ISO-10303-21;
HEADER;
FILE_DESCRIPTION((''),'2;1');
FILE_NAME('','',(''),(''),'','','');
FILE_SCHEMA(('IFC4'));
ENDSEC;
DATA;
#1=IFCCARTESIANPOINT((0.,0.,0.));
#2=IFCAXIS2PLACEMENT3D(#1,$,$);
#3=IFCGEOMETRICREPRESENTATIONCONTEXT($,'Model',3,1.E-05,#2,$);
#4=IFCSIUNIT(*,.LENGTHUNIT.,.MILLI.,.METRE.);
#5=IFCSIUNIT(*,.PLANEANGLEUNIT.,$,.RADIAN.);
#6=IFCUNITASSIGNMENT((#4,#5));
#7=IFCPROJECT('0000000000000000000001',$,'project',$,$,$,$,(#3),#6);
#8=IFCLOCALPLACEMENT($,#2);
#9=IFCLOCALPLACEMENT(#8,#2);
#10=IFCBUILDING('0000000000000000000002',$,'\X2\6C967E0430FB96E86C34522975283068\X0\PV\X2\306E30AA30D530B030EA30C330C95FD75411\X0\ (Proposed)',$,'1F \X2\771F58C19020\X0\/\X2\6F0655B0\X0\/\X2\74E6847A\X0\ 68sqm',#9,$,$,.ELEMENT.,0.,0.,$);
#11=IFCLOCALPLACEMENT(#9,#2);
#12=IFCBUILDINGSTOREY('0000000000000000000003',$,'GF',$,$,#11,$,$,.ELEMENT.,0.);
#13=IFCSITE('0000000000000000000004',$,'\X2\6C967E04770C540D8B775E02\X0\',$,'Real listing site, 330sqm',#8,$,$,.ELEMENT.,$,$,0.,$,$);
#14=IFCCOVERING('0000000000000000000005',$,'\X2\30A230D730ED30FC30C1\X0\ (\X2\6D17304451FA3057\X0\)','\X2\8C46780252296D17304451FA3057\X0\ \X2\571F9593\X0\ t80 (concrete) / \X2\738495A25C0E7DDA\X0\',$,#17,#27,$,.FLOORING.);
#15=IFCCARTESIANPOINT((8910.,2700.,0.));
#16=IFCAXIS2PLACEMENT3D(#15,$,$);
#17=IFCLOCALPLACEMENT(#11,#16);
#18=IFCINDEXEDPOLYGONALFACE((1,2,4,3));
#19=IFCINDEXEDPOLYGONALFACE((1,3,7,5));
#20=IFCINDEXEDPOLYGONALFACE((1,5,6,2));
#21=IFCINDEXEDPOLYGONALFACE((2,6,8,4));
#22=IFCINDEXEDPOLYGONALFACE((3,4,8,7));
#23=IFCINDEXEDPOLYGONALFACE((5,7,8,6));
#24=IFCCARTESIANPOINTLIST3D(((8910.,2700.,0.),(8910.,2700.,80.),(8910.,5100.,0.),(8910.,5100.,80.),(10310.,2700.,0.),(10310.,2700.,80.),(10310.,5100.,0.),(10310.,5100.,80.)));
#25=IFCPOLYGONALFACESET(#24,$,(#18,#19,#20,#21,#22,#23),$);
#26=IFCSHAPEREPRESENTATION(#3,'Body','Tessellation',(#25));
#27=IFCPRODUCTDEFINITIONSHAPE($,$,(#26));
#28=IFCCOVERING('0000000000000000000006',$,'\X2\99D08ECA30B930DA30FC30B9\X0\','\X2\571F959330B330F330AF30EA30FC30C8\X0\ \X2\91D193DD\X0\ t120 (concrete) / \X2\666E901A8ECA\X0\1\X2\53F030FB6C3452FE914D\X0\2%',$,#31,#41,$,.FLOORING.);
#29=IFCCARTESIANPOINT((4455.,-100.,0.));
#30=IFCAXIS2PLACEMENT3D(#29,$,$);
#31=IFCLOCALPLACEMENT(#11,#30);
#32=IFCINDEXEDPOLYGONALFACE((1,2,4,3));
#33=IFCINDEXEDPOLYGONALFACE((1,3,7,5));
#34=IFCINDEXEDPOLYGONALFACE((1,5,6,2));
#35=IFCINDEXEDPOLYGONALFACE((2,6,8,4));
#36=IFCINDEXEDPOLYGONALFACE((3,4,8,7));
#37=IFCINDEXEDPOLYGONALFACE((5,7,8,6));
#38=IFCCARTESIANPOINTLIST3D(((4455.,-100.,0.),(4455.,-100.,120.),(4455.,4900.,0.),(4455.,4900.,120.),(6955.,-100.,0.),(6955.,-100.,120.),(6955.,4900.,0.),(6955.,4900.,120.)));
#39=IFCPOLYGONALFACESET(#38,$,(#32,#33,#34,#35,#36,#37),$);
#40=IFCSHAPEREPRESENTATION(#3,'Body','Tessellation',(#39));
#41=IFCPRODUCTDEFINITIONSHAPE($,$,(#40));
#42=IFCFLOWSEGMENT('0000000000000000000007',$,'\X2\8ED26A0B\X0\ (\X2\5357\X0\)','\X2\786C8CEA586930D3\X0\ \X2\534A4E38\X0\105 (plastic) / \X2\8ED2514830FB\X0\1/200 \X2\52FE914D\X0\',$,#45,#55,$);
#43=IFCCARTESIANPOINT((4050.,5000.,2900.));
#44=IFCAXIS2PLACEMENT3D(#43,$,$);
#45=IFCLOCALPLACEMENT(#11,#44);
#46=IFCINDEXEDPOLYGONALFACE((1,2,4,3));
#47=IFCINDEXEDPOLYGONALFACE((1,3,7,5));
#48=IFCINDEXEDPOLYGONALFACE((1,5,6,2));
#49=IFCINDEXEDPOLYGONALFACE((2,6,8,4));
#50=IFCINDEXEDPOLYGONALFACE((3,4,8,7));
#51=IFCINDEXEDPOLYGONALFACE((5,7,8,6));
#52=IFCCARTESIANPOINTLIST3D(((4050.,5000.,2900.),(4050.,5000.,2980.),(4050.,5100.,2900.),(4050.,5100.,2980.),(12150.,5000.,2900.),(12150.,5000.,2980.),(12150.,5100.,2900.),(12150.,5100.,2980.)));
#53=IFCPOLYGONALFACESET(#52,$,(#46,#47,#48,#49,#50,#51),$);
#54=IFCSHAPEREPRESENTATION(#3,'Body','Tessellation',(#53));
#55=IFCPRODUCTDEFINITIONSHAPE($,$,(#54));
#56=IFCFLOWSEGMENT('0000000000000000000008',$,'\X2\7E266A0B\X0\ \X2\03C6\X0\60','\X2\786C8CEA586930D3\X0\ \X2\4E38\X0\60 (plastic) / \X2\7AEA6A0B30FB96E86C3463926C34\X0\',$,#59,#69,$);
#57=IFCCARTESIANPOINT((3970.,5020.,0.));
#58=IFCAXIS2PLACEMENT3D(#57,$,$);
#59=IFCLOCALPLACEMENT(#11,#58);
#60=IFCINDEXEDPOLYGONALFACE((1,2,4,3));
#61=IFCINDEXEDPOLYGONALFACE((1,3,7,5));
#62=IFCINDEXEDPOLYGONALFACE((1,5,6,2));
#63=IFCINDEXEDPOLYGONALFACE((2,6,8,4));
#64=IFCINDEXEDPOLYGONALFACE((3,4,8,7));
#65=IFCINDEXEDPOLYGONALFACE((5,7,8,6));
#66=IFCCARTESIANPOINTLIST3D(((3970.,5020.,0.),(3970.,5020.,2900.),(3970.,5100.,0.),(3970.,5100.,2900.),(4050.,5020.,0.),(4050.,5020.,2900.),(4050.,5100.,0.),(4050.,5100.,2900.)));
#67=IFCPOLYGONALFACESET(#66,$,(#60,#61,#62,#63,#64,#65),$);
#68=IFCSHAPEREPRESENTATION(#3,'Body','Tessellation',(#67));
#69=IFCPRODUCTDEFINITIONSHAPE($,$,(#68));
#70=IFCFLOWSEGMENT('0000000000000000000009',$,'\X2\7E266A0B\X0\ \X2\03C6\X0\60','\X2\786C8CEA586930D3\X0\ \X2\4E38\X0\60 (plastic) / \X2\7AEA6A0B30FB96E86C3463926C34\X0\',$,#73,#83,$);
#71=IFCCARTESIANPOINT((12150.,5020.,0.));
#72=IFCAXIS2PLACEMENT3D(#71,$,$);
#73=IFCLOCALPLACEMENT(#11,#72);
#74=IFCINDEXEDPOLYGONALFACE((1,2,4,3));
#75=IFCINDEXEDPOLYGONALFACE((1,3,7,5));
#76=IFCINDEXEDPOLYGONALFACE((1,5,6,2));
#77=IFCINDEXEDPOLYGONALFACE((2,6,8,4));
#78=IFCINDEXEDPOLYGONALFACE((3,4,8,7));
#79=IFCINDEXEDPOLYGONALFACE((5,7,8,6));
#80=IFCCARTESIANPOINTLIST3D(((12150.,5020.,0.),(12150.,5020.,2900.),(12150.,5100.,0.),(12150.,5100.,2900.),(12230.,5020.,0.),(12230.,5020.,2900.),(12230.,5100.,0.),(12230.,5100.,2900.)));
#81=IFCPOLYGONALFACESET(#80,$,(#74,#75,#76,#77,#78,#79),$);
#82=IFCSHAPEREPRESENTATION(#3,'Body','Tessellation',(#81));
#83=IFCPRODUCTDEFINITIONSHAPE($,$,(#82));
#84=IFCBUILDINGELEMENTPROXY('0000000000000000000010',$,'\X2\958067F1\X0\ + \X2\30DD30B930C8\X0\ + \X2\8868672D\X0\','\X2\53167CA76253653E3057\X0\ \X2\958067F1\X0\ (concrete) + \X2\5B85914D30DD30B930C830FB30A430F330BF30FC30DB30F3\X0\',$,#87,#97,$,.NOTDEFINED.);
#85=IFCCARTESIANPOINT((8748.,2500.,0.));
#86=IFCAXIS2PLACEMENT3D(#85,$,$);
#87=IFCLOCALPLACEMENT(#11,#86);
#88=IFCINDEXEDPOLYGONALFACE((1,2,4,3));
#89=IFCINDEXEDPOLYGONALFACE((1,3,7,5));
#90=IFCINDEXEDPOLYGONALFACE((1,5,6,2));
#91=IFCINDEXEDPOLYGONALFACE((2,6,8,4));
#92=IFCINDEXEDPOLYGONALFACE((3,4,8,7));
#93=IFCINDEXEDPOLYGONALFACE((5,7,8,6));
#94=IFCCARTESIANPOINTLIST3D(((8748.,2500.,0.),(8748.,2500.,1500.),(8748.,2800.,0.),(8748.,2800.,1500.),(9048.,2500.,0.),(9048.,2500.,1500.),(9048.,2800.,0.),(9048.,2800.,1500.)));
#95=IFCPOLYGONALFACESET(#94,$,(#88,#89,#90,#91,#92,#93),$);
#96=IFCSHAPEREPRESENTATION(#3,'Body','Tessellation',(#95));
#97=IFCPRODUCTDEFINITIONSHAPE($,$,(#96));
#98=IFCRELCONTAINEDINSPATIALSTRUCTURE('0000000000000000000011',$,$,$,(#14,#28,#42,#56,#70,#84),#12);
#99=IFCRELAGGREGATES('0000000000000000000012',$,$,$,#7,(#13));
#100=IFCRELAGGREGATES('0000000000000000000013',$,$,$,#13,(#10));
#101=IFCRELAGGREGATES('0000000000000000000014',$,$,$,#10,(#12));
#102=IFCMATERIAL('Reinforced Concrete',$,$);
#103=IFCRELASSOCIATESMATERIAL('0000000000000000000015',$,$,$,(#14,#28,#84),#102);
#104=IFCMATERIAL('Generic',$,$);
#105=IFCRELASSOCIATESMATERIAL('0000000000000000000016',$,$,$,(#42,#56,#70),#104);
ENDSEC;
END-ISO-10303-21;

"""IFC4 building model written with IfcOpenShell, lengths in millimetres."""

from ifc_helpers import new_model, si_unit, frame, frame_2d, origin, place, context, project, spatial, rectangle, extrude, material, element, save


model = new_model("IFC4")

# Units and contexts
model_context = context("Model", 3, precision=1e-05, world=origin())
ifc_project = project(units=[si_unit("LENGTHUNIT", "METRE", prefix="MILLI"), si_unit("PLANEANGLEUNIT", "RADIAN")], contexts=[model_context])

# Site, building, storey
site_placement = place(None, origin())
site = spatial("IfcSite", under=ifc_project, at=site_placement, Name="沖縄県名護市", ObjectType="Real listing site, 330sqm", CompositionType="ELEMENT", RefElevation=0.0)
building_placement = place(site_placement, origin())
building = spatial("IfcBuilding", under=site, at=building_placement, Name="沖縄・雨水利用とPVのオフグリッド志向 (Proposed)", ObjectType="1F 真壁造/漆喰/瓦葺 68sqm", CompositionType="ELEMENT", ElevationOfRefHeight=0.0, ElevationOfTerrain=0.0)
storey_placement = place(building_placement, origin())
storey = spatial("IfcBuildingStorey", under=building, at=storey_placement, Name="GF", CompositionType="ELEMENT", Elevation=0.0)

# Shared definitions
ifc_material_1 = material(Name="Reinforced Concrete")

# Coverings
ifc_material_2 = material(Name="Generic")
covering_1_placement = place(storey_placement, frame((8910.0, 2700.0, 0.0)))
element("IfcCovering", 1, at=covering_1_placement, inside=storey, material=ifc_material_1, Name="アプローチ (洗い出し)", Description="豆砂利洗い出し 土間 t80 (concrete) / 玄関導線", PredefinedType="FLOORING", context=model_context, shape_type="SweptSolid", body=[
    extrude(rectangle(XDim=1400.0, YDim=2400.0, at=frame_2d((700.0, 1200.0))), frame((8910.0, 2700.0, 0.0)), (0.0, 0.0, 1.0), 80.0),
])
covering_2_placement = place(storey_placement, frame((4455.0, -100.0, 0.0)))
element("IfcCovering", 2, at=covering_2_placement, inside=storey, material=ifc_material_1, Name="駐車スペース", Description="土間コンクリート 金鏝 t120 (concrete) / 普通車1台・水勾配2%", PredefinedType="FLOORING", context=model_context, shape_type="SweptSolid", body=[
    extrude(rectangle(XDim=2500.0, YDim=5000.0, at=frame_2d((1250.0, 2500.0))), frame((4455.0, -100.0, 0.0)), (0.0, 0.0, 1.0), 120.0),
])

# Flow segments
flow_segment_1_placement = place(storey_placement, frame((4050.0, 5000.0, 2900.0)))
element("IfcFlowSegment", 3, at=flow_segment_1_placement, inside=storey, material=ifc_material_2, Name="軒樋 (南)", Description="硬質塩ビ 半丸105 (plastic) / 軒先・1/200 勾配", context=model_context, shape_type="SweptSolid", body=[
    extrude(rectangle(XDim=8100.0, YDim=100.0, at=frame_2d((4050.0, 50.0))), frame((4050.0, 5000.0, 2900.0)), (0.0, 0.0, 1.0), 80.0),
])
flow_segment_2_placement = place(storey_placement, frame((3970.0, 5020.0, 0.0)))
element("IfcFlowSegment", 4, at=flow_segment_2_placement, inside=storey, material=ifc_material_2, Name="縦樋 φ60", Description="硬質塩ビ 丸60 (plastic) / 竪樋・雨水排水", context=model_context, shape_type="SweptSolid", body=[
    extrude(rectangle(XDim=80.0, YDim=80.0, at=frame_2d((40.0, 40.0))), frame((3970.0, 5020.0, 0.0)), (0.0, 0.0, 1.0), 2900.0),
])
flow_segment_3_placement = place(storey_placement, frame((12150.0, 5020.0, 0.0)))
element("IfcFlowSegment", 5, at=flow_segment_3_placement, inside=storey, material=ifc_material_2, Name="縦樋 φ60", Description="硬質塩ビ 丸60 (plastic) / 竪樋・雨水排水", context=model_context, shape_type="SweptSolid", body=[
    extrude(rectangle(XDim=80.0, YDim=80.0, at=frame_2d((40.0, 40.0))), frame((12150.0, 5020.0, 0.0)), (0.0, 0.0, 1.0), 2900.0),
])

# Building element proxy
proxy_placement = place(storey_placement, frame((8748.0, 2500.0, 0.0)))
element("IfcBuildingElementProxy", 6, at=proxy_placement, inside=storey, material=ifc_material_1, Name="門柱 + ポスト + 表札", Description="化粧打放し 門柱 (concrete) + 宅配ポスト・インターホン", PredefinedType="NOTDEFINED", context=model_context, shape_type="SweptSolid", body=[
    extrude(rectangle(XDim=300.0, YDim=300.0, at=frame_2d((150.0, 150.0))), frame((8748.0, 2500.0, 0.0)), (0.0, 0.0, 1.0), 1500.0),
])

save(model, "model.ifc")
